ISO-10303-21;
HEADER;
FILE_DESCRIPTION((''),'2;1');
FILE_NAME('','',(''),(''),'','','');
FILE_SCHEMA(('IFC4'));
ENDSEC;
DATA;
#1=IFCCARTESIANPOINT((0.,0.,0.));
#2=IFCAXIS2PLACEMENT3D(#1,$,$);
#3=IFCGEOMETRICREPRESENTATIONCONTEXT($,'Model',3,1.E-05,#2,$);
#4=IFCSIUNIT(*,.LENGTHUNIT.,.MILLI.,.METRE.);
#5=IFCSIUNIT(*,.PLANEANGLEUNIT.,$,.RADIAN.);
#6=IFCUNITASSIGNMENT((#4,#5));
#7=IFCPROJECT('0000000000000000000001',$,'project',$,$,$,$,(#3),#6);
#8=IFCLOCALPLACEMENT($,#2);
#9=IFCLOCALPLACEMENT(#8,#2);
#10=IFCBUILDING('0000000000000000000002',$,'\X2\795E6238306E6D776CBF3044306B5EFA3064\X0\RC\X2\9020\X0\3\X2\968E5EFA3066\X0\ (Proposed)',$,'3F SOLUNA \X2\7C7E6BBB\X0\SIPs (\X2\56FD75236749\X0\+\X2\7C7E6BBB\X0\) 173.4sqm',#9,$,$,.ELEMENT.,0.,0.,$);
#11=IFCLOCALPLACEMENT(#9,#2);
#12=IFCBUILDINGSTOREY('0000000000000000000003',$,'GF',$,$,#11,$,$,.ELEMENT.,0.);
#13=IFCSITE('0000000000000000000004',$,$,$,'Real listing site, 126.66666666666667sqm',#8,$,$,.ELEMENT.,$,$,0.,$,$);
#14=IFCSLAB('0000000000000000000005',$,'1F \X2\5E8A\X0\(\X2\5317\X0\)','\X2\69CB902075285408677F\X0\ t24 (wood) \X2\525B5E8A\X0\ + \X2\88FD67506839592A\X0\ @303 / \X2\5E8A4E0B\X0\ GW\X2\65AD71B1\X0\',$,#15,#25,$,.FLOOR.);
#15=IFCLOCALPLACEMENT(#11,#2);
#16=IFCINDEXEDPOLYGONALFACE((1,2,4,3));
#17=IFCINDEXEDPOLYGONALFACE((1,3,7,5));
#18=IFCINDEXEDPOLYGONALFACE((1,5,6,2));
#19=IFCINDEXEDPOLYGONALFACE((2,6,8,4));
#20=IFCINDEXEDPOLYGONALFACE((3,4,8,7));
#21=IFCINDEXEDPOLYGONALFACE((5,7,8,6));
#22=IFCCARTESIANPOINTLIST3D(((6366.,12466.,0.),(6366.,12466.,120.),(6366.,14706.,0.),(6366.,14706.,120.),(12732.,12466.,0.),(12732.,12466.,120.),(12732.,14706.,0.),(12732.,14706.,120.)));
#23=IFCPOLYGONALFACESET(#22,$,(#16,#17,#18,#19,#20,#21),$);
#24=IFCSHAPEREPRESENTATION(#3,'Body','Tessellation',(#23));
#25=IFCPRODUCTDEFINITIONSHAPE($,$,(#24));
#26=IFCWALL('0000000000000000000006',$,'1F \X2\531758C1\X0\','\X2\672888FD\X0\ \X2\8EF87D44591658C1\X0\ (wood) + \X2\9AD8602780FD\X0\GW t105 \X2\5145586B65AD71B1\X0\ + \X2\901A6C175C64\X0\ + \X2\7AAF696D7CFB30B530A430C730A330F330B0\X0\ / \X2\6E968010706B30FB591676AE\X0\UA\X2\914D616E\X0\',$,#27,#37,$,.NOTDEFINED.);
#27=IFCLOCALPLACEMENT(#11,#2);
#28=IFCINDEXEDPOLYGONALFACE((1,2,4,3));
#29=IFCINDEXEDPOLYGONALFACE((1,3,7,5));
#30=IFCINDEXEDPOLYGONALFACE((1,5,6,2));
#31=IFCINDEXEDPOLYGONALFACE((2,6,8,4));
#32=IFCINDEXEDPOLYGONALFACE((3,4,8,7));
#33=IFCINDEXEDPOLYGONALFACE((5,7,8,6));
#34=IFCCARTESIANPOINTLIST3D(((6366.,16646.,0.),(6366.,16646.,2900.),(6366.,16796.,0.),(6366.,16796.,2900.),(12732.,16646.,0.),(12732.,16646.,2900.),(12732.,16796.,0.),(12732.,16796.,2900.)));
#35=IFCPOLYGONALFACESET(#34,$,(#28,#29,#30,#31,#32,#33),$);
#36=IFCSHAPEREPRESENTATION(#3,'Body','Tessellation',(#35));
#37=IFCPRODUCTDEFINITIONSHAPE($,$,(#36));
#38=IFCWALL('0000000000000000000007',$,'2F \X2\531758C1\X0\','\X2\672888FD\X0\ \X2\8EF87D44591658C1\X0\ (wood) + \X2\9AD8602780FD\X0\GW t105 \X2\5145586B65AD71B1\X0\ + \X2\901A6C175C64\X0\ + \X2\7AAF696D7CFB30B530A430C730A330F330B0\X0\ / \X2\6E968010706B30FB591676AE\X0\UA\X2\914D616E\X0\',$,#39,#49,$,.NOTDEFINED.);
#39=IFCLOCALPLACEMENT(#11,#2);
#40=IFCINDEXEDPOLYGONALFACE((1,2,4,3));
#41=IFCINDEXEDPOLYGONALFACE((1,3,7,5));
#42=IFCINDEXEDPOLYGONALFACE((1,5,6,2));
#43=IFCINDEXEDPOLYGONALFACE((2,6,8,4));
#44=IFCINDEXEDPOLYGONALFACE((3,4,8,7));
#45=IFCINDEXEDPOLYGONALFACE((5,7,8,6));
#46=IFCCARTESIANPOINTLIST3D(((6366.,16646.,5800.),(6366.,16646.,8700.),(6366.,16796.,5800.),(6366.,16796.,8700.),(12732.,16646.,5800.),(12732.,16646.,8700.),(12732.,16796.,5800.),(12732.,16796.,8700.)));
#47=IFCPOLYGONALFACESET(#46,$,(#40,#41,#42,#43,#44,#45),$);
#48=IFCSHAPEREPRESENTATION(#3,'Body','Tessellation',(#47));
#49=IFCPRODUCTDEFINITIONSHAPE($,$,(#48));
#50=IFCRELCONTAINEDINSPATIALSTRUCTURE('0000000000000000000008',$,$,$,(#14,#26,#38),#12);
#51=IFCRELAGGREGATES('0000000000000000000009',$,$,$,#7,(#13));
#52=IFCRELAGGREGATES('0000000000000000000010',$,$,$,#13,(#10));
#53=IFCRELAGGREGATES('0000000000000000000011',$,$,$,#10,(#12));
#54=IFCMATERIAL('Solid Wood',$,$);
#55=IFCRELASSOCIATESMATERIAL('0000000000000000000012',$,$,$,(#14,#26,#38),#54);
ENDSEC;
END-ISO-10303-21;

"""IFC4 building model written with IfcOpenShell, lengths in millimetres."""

from ifc_helpers import new_model, si_unit, frame, frame_2d, origin, place, context, project, spatial, rectangle, extrude, material, element, save


model = new_model("IFC4")

# Units and contexts
model_context = context("Model", 3, precision=1e-05, world=origin())
ifc_project = project(units=[si_unit("LENGTHUNIT", "METRE", prefix="MILLI"), si_unit("PLANEANGLEUNIT", "RADIAN")], contexts=[model_context])

# Site, building, storey
site_placement = place(None, origin())
site = spatial("IfcSite", under=ifc_project, at=site_placement, ObjectType="Real listing site, 126.66666666666667sqm", CompositionType="ELEMENT", RefElevation=0.0)
building_placement = place(site_placement, origin())
building = spatial("IfcBuilding", under=site, at=building_placement, Name="神戸の海沿いに建つRC造3階建て (Proposed)", ObjectType="3F SOLUNA 籾殻SIPs (国産杉+籾殻) 173.4sqm", CompositionType="ELEMENT", ElevationOfRefHeight=0.0, ElevationOfTerrain=0.0)
storey_placement = place(building_placement, origin())
storey = spatial("IfcBuildingStorey", under=building, at=storey_placement, Name="GF", CompositionType="ELEMENT", Elevation=0.0)

# Slab
ifc_material_1 = material(Name="Solid Wood")
slab_1_placement = place(storey_placement, frame((3183.0, 6233.0, 0.0)))
element("IfcSlab", 1, at=slab_1_placement, inside=storey, material=ifc_material_1, Name="1F 床(北)", Description="構造用合板 t24 (wood) 剛床 + 製材根太 @303 / 床下 GW断熱", PredefinedType="FLOOR", context=model_context, shape_type="SweptSolid", body=[
    extrude(rectangle(XDim=6366.0, YDim=2240.0, at=frame_2d((3183.0, 1120.0))), frame((3183.0, 6233.0, 0.0)), (0.0, 0.0, 1.0), 120.0),
])

# Wall
wall_1_placement = place(storey_placement, frame((3183.0, 8323.0, 0.0)))
element("IfcWall", 2, at=wall_1_placement, inside=storey, material=ifc_material_1, Name="1F 北壁", Description="木製 軸組外壁 (wood) + 高性能GW t105 充填断熱 + 通気層 + 窯業系サイディング / 準耐火・外皮UA配慮", PredefinedType="NOTDEFINED", context=model_context, shape_type="SweptSolid", body=[
    extrude(rectangle(XDim=6366.0, YDim=150.0, at=frame_2d((3183.0, 75.0))), frame((3183.0, 8323.0, 0.0)), (0.0, 0.0, 1.0), 2900.0),
])

# Wall
wall_2_placement = place(storey_placement, frame((3183.0, 8323.0, 2900.0)))
element("IfcWall", 3, at=wall_2_placement, inside=storey, material=ifc_material_1, Name="2F 北壁", Description="木製 軸組外壁 (wood) + 高性能GW t105 充填断熱 + 通気層 + 窯業系サイディング / 準耐火・外皮UA配慮", PredefinedType="NOTDEFINED", context=model_context, shape_type="SweptSolid", body=[
    extrude(rectangle(XDim=6366.0, YDim=150.0, at=frame_2d((3183.0, 75.0))), frame((3183.0, 8323.0, 2900.0)), (0.0, 0.0, 1.0), 2900.0),
])

save(model, "model.ifc")
